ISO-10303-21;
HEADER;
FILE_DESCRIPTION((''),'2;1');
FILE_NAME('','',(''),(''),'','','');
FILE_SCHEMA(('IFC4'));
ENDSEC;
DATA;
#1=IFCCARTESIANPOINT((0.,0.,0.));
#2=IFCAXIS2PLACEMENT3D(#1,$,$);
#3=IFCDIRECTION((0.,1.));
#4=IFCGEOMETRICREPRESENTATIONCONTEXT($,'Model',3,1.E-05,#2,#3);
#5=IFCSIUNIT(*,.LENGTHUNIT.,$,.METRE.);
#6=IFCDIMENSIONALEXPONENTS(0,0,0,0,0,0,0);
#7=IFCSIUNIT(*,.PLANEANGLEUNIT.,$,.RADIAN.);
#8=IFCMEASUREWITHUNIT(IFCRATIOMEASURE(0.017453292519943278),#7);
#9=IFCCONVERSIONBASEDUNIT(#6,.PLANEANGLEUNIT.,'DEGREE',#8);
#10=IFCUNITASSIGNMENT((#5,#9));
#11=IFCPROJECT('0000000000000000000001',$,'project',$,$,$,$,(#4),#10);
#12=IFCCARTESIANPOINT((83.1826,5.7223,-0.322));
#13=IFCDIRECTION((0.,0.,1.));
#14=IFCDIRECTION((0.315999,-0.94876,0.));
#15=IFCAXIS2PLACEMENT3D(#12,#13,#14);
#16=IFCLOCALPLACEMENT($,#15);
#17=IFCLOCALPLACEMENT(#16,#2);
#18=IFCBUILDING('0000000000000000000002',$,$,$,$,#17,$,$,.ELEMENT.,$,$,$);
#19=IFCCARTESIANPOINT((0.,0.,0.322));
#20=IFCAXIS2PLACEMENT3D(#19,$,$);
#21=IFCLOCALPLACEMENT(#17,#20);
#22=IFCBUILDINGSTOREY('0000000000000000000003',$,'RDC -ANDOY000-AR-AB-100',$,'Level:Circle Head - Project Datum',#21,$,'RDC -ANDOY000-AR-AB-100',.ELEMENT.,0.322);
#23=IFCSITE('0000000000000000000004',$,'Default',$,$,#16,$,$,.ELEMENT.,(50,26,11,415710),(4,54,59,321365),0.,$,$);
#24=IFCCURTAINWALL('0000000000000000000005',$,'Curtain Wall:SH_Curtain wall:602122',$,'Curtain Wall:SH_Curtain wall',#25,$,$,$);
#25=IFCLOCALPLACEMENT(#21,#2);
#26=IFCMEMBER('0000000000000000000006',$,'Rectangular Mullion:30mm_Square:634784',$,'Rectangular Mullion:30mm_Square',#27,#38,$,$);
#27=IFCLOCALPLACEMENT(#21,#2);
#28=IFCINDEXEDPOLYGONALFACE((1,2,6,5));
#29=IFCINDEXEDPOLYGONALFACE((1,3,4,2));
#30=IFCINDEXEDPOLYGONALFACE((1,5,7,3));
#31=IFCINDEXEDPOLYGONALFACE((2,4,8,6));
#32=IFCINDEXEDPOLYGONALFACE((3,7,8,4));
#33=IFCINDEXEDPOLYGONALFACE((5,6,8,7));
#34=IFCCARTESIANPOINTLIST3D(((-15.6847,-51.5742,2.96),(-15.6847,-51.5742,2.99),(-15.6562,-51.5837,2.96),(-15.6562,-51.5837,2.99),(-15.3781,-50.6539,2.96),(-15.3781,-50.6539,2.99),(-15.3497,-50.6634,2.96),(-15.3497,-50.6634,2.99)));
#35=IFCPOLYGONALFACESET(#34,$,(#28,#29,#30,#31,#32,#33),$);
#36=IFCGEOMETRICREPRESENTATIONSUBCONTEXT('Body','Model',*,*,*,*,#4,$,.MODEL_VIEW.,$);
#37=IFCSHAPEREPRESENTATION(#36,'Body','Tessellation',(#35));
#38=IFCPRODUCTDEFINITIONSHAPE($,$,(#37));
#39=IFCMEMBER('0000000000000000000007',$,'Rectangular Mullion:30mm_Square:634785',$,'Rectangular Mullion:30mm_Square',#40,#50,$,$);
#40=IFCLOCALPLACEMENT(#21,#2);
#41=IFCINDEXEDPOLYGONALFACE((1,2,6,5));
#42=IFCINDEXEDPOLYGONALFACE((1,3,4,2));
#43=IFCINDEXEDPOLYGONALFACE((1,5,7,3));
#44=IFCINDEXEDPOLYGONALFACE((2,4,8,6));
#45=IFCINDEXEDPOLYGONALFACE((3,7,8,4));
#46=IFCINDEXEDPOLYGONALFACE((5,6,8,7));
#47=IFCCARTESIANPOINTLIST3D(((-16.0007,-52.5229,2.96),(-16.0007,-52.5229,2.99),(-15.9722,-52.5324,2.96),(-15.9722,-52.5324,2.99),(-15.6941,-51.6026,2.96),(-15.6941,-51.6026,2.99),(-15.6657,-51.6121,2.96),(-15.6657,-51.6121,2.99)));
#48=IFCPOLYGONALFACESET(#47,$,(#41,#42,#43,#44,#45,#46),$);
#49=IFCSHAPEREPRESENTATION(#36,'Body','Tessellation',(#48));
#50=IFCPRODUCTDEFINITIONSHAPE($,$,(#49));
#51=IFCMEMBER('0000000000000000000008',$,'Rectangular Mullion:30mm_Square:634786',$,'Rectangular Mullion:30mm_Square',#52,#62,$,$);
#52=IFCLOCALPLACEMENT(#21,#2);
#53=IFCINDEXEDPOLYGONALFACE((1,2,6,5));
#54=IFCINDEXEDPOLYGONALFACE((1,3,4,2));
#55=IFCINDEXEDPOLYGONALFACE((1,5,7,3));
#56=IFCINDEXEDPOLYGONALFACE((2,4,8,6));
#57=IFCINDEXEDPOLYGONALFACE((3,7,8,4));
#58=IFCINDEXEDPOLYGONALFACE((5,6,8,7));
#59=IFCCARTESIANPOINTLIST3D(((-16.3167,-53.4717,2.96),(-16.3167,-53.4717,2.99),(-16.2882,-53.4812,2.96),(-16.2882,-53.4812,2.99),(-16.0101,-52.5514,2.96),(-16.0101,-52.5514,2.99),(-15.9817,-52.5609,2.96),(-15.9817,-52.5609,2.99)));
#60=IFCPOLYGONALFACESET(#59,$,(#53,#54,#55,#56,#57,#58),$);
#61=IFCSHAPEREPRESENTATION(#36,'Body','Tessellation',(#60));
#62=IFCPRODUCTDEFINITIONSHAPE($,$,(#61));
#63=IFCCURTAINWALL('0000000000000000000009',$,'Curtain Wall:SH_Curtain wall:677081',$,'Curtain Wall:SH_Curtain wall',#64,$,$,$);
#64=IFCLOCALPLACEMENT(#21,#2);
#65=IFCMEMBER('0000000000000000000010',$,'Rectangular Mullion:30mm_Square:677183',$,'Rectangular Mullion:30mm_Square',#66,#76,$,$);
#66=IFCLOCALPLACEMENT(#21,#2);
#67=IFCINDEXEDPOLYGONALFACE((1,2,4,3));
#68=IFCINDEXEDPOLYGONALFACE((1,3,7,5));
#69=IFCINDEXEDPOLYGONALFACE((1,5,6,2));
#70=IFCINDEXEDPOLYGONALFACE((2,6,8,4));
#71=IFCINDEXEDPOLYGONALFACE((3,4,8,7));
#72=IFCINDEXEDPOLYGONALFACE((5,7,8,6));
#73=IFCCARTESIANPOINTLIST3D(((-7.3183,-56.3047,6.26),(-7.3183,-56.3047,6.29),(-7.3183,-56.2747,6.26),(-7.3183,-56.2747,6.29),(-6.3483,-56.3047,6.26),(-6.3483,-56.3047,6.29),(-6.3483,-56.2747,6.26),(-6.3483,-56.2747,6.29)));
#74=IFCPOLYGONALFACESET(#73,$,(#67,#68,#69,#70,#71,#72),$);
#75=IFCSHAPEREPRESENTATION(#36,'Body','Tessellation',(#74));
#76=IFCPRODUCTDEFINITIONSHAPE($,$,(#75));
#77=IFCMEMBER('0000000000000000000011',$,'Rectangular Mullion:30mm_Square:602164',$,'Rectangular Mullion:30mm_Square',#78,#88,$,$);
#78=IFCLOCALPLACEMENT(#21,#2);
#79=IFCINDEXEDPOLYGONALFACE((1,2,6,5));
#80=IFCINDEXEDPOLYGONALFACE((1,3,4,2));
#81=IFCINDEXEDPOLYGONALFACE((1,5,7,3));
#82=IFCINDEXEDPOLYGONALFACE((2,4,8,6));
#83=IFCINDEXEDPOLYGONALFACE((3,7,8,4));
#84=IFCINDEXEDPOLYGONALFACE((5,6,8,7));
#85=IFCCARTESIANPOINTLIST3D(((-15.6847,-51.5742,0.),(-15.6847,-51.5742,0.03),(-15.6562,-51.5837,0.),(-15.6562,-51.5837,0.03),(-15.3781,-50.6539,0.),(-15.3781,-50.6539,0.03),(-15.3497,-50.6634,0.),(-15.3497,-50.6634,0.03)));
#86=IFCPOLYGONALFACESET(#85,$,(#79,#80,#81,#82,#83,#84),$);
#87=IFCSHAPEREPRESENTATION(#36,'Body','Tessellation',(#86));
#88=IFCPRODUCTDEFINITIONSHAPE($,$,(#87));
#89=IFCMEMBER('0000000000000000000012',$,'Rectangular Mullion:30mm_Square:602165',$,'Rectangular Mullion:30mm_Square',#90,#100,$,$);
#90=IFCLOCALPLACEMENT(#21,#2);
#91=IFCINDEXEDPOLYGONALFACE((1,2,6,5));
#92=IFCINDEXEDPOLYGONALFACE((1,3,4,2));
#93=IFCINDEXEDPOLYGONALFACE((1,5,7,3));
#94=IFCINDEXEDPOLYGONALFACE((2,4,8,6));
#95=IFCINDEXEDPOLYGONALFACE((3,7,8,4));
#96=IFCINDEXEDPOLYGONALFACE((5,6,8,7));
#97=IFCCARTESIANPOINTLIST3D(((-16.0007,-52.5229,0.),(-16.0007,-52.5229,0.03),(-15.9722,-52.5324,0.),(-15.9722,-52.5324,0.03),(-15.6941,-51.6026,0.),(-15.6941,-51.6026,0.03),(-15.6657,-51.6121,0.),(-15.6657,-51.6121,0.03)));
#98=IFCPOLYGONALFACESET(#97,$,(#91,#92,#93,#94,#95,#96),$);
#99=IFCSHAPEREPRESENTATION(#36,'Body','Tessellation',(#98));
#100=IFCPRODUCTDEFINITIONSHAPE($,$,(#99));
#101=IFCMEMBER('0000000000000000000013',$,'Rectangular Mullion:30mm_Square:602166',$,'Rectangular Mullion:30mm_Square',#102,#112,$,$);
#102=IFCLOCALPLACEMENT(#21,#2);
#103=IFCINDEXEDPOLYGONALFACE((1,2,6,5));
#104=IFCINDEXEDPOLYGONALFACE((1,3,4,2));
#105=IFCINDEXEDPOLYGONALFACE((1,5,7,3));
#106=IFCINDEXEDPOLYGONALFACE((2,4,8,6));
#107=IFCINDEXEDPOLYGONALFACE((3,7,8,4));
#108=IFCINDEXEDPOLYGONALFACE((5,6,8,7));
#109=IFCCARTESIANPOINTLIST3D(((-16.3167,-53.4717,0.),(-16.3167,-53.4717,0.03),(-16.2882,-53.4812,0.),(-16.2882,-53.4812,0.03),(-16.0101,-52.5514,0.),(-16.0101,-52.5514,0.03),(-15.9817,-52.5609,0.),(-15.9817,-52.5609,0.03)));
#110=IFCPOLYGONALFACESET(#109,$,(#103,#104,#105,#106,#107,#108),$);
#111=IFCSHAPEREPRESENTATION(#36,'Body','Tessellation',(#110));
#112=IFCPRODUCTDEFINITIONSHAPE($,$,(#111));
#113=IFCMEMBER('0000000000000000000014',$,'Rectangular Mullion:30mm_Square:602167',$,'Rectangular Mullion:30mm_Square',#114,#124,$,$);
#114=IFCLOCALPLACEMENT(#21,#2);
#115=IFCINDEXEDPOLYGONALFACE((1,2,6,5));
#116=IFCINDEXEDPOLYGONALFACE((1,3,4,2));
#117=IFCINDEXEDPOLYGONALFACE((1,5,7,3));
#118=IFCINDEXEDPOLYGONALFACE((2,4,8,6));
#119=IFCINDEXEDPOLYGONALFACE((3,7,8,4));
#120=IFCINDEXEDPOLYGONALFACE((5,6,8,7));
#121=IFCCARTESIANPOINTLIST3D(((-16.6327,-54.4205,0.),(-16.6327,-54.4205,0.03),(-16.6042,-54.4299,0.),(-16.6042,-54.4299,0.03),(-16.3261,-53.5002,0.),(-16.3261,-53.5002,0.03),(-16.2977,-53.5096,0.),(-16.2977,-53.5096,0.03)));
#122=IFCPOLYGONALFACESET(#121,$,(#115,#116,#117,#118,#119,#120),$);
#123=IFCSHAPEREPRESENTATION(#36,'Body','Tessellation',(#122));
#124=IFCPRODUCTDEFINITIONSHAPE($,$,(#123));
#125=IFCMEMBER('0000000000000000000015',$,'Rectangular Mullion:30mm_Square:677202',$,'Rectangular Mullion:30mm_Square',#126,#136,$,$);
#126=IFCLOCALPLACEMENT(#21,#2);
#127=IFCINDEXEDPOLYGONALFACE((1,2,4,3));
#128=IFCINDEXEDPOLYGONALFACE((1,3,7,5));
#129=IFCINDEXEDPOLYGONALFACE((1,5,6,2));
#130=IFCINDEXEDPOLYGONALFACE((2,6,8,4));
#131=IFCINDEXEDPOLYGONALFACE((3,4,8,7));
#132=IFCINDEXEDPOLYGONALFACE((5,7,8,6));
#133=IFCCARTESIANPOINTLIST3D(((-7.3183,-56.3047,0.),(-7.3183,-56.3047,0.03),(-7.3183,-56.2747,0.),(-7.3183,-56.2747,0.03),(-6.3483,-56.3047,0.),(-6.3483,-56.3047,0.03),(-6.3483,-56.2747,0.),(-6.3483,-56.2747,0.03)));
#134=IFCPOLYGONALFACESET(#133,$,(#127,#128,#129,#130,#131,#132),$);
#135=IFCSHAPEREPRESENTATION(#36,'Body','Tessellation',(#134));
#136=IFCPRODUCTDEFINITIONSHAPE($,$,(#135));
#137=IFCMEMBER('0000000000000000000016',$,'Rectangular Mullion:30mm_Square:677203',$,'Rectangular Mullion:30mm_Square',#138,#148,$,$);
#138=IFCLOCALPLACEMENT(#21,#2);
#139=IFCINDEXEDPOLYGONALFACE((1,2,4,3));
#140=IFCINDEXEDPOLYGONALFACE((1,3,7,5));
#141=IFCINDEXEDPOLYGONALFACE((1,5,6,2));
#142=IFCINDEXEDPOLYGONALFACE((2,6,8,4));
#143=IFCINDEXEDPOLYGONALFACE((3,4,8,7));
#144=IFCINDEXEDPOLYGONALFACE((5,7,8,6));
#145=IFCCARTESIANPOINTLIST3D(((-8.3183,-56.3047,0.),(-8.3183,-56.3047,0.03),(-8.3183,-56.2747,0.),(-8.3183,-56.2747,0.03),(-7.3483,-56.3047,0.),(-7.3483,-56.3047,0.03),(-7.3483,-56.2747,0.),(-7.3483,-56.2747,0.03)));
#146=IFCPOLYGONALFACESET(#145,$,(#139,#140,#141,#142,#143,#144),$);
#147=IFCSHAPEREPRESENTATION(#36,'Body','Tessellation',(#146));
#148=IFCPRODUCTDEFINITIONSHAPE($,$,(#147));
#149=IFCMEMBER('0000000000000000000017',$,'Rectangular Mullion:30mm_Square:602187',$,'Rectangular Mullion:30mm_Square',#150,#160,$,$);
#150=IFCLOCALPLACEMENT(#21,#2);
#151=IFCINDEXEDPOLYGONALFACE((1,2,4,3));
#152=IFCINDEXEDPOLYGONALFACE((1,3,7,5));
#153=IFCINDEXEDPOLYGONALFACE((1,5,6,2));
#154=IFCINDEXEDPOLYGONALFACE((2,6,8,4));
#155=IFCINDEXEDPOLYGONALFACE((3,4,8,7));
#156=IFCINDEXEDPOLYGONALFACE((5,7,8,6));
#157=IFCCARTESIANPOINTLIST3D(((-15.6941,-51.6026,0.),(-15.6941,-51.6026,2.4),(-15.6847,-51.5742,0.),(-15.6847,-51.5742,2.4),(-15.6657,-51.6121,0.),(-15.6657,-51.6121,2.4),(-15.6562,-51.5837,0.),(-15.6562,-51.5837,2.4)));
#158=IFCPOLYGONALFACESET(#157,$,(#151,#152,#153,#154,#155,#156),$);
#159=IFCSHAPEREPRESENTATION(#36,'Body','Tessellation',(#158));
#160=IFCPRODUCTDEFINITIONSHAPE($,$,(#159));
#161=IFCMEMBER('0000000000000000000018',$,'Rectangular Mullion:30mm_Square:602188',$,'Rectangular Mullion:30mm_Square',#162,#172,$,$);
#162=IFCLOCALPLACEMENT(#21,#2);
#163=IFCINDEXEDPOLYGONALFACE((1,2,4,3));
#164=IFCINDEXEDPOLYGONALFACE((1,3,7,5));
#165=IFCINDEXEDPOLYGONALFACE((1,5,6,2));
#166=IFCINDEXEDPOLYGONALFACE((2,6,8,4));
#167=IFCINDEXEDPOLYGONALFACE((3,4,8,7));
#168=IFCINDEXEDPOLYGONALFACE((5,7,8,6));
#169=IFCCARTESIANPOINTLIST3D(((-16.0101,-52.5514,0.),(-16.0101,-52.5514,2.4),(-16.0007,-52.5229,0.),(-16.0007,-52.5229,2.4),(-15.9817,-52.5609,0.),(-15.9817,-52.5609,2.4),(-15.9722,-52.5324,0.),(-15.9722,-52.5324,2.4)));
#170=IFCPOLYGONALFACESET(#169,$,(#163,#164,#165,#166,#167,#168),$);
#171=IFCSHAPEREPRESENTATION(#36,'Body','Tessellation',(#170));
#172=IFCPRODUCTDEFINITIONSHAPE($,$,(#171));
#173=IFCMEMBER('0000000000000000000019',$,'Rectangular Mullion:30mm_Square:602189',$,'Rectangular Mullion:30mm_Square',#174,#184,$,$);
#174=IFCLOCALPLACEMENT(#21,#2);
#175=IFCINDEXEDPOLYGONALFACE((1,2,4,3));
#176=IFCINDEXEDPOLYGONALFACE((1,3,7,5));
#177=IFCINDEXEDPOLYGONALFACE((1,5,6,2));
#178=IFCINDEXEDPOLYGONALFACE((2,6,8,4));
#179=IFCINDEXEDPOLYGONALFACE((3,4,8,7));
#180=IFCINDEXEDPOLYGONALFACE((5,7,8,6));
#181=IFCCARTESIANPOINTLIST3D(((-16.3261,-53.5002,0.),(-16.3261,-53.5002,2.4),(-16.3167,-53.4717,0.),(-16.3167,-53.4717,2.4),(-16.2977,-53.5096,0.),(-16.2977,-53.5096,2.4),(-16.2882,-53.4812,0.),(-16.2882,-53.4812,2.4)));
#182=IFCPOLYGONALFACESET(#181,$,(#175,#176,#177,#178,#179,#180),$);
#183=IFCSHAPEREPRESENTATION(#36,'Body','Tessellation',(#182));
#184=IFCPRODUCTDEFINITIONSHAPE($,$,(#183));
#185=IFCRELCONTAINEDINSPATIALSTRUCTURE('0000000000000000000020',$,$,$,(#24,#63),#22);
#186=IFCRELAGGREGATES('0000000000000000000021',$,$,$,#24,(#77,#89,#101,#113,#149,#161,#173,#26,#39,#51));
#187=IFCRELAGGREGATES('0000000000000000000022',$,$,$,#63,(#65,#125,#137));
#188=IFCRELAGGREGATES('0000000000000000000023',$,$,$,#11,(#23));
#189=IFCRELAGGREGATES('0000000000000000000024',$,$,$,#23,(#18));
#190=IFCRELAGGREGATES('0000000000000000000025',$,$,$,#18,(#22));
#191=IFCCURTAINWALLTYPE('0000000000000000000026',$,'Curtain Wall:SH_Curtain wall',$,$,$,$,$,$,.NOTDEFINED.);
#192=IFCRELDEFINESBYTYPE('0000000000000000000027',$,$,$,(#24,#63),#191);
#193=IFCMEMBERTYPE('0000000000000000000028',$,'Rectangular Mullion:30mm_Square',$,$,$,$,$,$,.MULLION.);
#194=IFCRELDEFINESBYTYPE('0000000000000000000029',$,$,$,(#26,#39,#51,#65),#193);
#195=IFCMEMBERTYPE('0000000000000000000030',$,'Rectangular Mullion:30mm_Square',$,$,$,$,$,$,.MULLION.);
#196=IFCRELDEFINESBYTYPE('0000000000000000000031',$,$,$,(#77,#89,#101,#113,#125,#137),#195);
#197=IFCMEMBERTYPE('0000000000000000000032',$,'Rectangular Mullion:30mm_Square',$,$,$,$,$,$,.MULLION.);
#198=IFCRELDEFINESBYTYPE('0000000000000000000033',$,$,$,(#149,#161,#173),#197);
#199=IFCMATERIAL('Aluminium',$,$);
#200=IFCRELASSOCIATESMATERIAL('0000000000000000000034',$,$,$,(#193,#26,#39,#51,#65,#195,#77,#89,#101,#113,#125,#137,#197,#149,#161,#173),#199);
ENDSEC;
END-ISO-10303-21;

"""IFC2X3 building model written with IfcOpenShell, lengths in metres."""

from ifc_helpers import new_model, entity, si_unit, converted_unit, direction, frame, origin, origin_2d_with_axis, place, context, subcontext, project, spatial, rectangle, extrude, source, transform, mapped, material, type_object, type_shapes, element, aggregate, save


model = new_model("IFC2X3")

# Units and contexts
model_context = context("Model", 3, precision=1e-05, world=origin(), true_north=direction((0.0, 1.0)))
body_context = subcontext(model_context, "Body", "Model", "MODEL_VIEW")
ifc_project = project(units=[si_unit("LENGTHUNIT", "METRE"), converted_unit("PLANEANGLEUNIT", "DEGREE", entity("IfcRatioMeasure", 0.017453292519943278), si_unit("PLANEANGLEUNIT", "RADIAN"), dimensions=[0, 0, 0, 0, 0, 0, 0])], contexts=[model_context])

# Site, building, storey
site_placement = place(None, frame((83.1826, 5.7223, -0.322), z_axis=(0.0, 0.0, 1.0), x_axis=(0.315999, -0.94876, 0.0)))
site = spatial("IfcSite", under=ifc_project, at=site_placement, Name="Default", CompositionType="ELEMENT", RefLatitude=(50, 26, 11, 415710), RefLongitude=(4, 54, 59, 321365), RefElevation=0.0)
building_placement = place(site_placement, origin())
building = spatial("IfcBuilding", under=site, at=building_placement, CompositionType="ELEMENT")
storey_placement = place(building_placement, frame((0.0, 0.0, 0.322)))
storey = spatial("IfcBuildingStorey", under=building, at=storey_placement, Name="RDC -ANDOY000-AR-AB-100", ObjectType="Level:Circle Head - Project Datum", LongName="RDC -ANDOY000-AR-AB-100", CompositionType="ELEMENT", Elevation=0.322)

# Curtain wall, members
curtain_wall_type = type_object("IfcCurtainWallType", Name="Curtain Wall:SH_Curtain wall", PredefinedType="NOTDEFINED")
curtain_wall_1_placement = place(storey_placement, frame((0.0, 0.0, -0.322)))
curtain_wall_1 = element("IfcCurtainWall", 1, at=curtain_wall_1_placement, inside=storey, type_object=curtain_wall_type, Name="Curtain Wall:SH_Curtain wall:602122", ObjectType="Curtain Wall:SH_Curtain wall")
ifc_material_1 = material(Name="Aluminium")
member_type_1 = type_object("IfcMemberType", Name="Rectangular Mullion:30mm_Square", PredefinedType="MULLION", material=ifc_material_1)
shared_shape_1 = source(origin(), body_context, "Body", "SweptSolid", [
    extrude(rectangle(XDim=0.03, YDim=0.03, at=origin_2d_with_axis()), frame((-0.015, 0.0, -0.97), z_axis=(0.0, 0.0, 1.0), x_axis=(0.0, -1.0, 0.0)), (0.0, 0.0, 1.0), 0.97),
])
type_shapes(member_type_1, [shared_shape_1])
member_1_placement = place(curtain_wall_1_placement, frame((-15.6704, -51.5789, 3.312), z_axis=(-0.316, -0.948759, 0.0), x_axis=(0.0, 0.0, 1.0)))
member_1 = element("IfcMember", 2, at=member_1_placement, type_object=member_type_1, material=ifc_material_1, Name="Rectangular Mullion:30mm_Square:634784", ObjectType="Rectangular Mullion:30mm_Square", context=body_context, shape_type="MappedRepresentation", body=[
    mapped(shared_shape_1, transform((0.0, 0.0, 0.0), scale=1.0)),
])
member_2_placement = place(curtain_wall_1_placement, frame((-15.9864, -52.5277, 3.312), z_axis=(-0.316, -0.948759, 0.0), x_axis=(0.0, 0.0, 1.0)))
member_2 = element("IfcMember", 3, at=member_2_placement, type_object=member_type_1, material=ifc_material_1, Name="Rectangular Mullion:30mm_Square:634785", ObjectType="Rectangular Mullion:30mm_Square", context=body_context, shape_type="MappedRepresentation", body=[
    mapped(shared_shape_1, transform((0.0, 0.0, 0.0), scale=1.0)),
])
member_3_placement = place(curtain_wall_1_placement, frame((-16.3024, -53.4764, 3.312), z_axis=(-0.316, -0.948759, 0.0), x_axis=(0.0, 0.0, 1.0)))
member_3 = element("IfcMember", 4, at=member_3_placement, type_object=member_type_1, material=ifc_material_1, Name="Rectangular Mullion:30mm_Square:634786", ObjectType="Rectangular Mullion:30mm_Square", context=body_context, shape_type="MappedRepresentation", body=[
    mapped(shared_shape_1, transform((0.0, 0.0, 0.0), scale=1.0)),
])

# Curtain wall, member
curtain_wall_2_placement = place(storey_placement, frame((0.0, 0.0, -0.322)))
curtain_wall_2 = element("IfcCurtainWall", 5, at=curtain_wall_2_placement, inside=storey, type_object=curtain_wall_type, Name="Curtain Wall:SH_Curtain wall:677081", ObjectType="Curtain Wall:SH_Curtain wall")
member_4_placement = place(curtain_wall_2_placement, frame((-7.3183, -56.2897, 6.612), z_axis=(-1.0, 0.0, 0.0), x_axis=(0.0, 0.0, 1.0)))
member_4 = element("IfcMember", 6, at=member_4_placement, type_object=member_type_1, material=ifc_material_1, Name="Rectangular Mullion:30mm_Square:677183", ObjectType="Rectangular Mullion:30mm_Square", context=body_context, shape_type="MappedRepresentation", body=[
    mapped(shared_shape_1, transform((0.0, 0.0, 0.0), scale=1.0)),
])

# Members
member_type_2 = type_object("IfcMemberType", Name="Rectangular Mullion:30mm_Square", PredefinedType="MULLION", material=ifc_material_1)
shared_shape_2 = source(origin(), body_context, "Body", "SweptSolid", [
    extrude(rectangle(XDim=0.03, YDim=0.03, at=origin_2d_with_axis()), frame((-0.015, 0.0, -0.97), z_axis=(0.0, 0.0, 1.0), x_axis=(0.0, -1.0, 0.0)), (0.0, 0.0, 1.0), 0.97),
])
type_shapes(member_type_2, [shared_shape_2])
member_5_placement = place(curtain_wall_1_placement, frame((-15.3639, -50.6586, 0.322), z_axis=(0.316, 0.948759, 0.0), x_axis=(0.0, 0.0, -1.0)))
member_5 = element("IfcMember", 7, at=member_5_placement, type_object=member_type_2, material=ifc_material_1, Name="Rectangular Mullion:30mm_Square:602164", ObjectType="Rectangular Mullion:30mm_Square", context=body_context, shape_type="MappedRepresentation", body=[
    mapped(shared_shape_2, transform((0.0, 0.0, 0.0), scale=1.0)),
])
member_6_placement = place(curtain_wall_1_placement, frame((-15.6799, -51.6074, 0.322), z_axis=(0.316, 0.948759, 0.0), x_axis=(0.0, 0.0, -1.0)))
member_6 = element("IfcMember", 8, at=member_6_placement, type_object=member_type_2, material=ifc_material_1, Name="Rectangular Mullion:30mm_Square:602165", ObjectType="Rectangular Mullion:30mm_Square", context=body_context, shape_type="MappedRepresentation", body=[
    mapped(shared_shape_2, transform((0.0, 0.0, 0.0), scale=1.0)),
])
member_7_placement = place(curtain_wall_1_placement, frame((-15.9959, -52.5561, 0.322), z_axis=(0.316, 0.948759, 0.0), x_axis=(0.0, 0.0, -1.0)))
member_7 = element("IfcMember", 9, at=member_7_placement, type_object=member_type_2, material=ifc_material_1, Name="Rectangular Mullion:30mm_Square:602166", ObjectType="Rectangular Mullion:30mm_Square", context=body_context, shape_type="MappedRepresentation", body=[
    mapped(shared_shape_2, transform((0.0, 0.0, 0.0), scale=1.0)),
])
member_8_placement = place(curtain_wall_1_placement, frame((-16.3119, -53.5049, 0.322), z_axis=(0.316, 0.948759, 0.0), x_axis=(0.0, 0.0, -1.0)))
member_8 = element("IfcMember", 10, at=member_8_placement, type_object=member_type_2, material=ifc_material_1, Name="Rectangular Mullion:30mm_Square:602167", ObjectType="Rectangular Mullion:30mm_Square", context=body_context, shape_type="MappedRepresentation", body=[
    mapped(shared_shape_2, transform((0.0, 0.0, 0.0), scale=1.0)),
])
member_9_placement = place(curtain_wall_2_placement, frame((-6.3483, -56.2897, 0.322), z_axis=(1.0, 0.0, 0.0), x_axis=(0.0, 0.0, -1.0)))
member_9 = element("IfcMember", 11, at=member_9_placement, type_object=member_type_2, material=ifc_material_1, Name="Rectangular Mullion:30mm_Square:677202", ObjectType="Rectangular Mullion:30mm_Square", context=body_context, shape_type="MappedRepresentation", body=[
    mapped(shared_shape_2, transform((0.0, 0.0, 0.0), scale=1.0)),
])
member_10_placement = place(curtain_wall_2_placement, frame((-7.3483, -56.2897, 0.322), z_axis=(1.0, 0.0, 0.0), x_axis=(0.0, 0.0, -1.0)))
member_10 = element("IfcMember", 12, at=member_10_placement, type_object=member_type_2, material=ifc_material_1, Name="Rectangular Mullion:30mm_Square:677203", ObjectType="Rectangular Mullion:30mm_Square", context=body_context, shape_type="MappedRepresentation", body=[
    mapped(shared_shape_2, transform((0.0, 0.0, 0.0), scale=1.0)),
])
member_type_3 = type_object("IfcMemberType", Name="Rectangular Mullion:30mm_Square", PredefinedType="MULLION", material=ifc_material_1)
shared_shape_3 = source(origin(), body_context, "Body", "SweptSolid", [
    extrude(rectangle(XDim=0.03, YDim=0.03, at=origin_2d_with_axis()), frame((0.0, 0.0, -2.4), z_axis=(0.0, 0.0, 1.0), x_axis=(0.0, -1.0, 0.0)), (0.0, 0.0, 1.0), 2.4),
])
type_shapes(member_type_3, [shared_shape_3])
member_11_placement = place(curtain_wall_1_placement, frame((-15.6752, -51.5932, 0.322), z_axis=(0.0, 0.0, -1.0), x_axis=(-0.316, -0.948759, 0.0)))
member_11 = element("IfcMember", 13, at=member_11_placement, type_object=member_type_3, material=ifc_material_1, Name="Rectangular Mullion:30mm_Square:602187", ObjectType="Rectangular Mullion:30mm_Square", context=body_context, shape_type="MappedRepresentation", body=[
    mapped(shared_shape_3, transform((0.0, 0.0, 0.0), scale=1.0)),
])
member_12_placement = place(curtain_wall_1_placement, frame((-15.9912, -52.5419, 0.322), z_axis=(0.0, 0.0, -1.0), x_axis=(-0.316, -0.948759, 0.0)))
member_12 = element("IfcMember", 14, at=member_12_placement, type_object=member_type_3, material=ifc_material_1, Name="Rectangular Mullion:30mm_Square:602188", ObjectType="Rectangular Mullion:30mm_Square", context=body_context, shape_type="MappedRepresentation", body=[
    mapped(shared_shape_3, transform((0.0, 0.0, 0.0), scale=1.0)),
])
member_13_placement = place(curtain_wall_1_placement, frame((-16.3072, -53.4907, 0.322), z_axis=(0.0, 0.0, -1.0), x_axis=(-0.316, -0.948759, 0.0)))
member_13 = element("IfcMember", 15, at=member_13_placement, type_object=member_type_3, material=ifc_material_1, Name="Rectangular Mullion:30mm_Square:602189", ObjectType="Rectangular Mullion:30mm_Square", context=body_context, shape_type="MappedRepresentation", body=[
    mapped(shared_shape_3, transform((0.0, 0.0, 0.0), scale=1.0)),
])

aggregate(curtain_wall_1, [member_5, member_6, member_7, member_8, member_11, member_12, member_13, member_1, member_2, member_3])
aggregate(curtain_wall_2, [member_4, member_9, member_10])

save(model, "model.ifc")
